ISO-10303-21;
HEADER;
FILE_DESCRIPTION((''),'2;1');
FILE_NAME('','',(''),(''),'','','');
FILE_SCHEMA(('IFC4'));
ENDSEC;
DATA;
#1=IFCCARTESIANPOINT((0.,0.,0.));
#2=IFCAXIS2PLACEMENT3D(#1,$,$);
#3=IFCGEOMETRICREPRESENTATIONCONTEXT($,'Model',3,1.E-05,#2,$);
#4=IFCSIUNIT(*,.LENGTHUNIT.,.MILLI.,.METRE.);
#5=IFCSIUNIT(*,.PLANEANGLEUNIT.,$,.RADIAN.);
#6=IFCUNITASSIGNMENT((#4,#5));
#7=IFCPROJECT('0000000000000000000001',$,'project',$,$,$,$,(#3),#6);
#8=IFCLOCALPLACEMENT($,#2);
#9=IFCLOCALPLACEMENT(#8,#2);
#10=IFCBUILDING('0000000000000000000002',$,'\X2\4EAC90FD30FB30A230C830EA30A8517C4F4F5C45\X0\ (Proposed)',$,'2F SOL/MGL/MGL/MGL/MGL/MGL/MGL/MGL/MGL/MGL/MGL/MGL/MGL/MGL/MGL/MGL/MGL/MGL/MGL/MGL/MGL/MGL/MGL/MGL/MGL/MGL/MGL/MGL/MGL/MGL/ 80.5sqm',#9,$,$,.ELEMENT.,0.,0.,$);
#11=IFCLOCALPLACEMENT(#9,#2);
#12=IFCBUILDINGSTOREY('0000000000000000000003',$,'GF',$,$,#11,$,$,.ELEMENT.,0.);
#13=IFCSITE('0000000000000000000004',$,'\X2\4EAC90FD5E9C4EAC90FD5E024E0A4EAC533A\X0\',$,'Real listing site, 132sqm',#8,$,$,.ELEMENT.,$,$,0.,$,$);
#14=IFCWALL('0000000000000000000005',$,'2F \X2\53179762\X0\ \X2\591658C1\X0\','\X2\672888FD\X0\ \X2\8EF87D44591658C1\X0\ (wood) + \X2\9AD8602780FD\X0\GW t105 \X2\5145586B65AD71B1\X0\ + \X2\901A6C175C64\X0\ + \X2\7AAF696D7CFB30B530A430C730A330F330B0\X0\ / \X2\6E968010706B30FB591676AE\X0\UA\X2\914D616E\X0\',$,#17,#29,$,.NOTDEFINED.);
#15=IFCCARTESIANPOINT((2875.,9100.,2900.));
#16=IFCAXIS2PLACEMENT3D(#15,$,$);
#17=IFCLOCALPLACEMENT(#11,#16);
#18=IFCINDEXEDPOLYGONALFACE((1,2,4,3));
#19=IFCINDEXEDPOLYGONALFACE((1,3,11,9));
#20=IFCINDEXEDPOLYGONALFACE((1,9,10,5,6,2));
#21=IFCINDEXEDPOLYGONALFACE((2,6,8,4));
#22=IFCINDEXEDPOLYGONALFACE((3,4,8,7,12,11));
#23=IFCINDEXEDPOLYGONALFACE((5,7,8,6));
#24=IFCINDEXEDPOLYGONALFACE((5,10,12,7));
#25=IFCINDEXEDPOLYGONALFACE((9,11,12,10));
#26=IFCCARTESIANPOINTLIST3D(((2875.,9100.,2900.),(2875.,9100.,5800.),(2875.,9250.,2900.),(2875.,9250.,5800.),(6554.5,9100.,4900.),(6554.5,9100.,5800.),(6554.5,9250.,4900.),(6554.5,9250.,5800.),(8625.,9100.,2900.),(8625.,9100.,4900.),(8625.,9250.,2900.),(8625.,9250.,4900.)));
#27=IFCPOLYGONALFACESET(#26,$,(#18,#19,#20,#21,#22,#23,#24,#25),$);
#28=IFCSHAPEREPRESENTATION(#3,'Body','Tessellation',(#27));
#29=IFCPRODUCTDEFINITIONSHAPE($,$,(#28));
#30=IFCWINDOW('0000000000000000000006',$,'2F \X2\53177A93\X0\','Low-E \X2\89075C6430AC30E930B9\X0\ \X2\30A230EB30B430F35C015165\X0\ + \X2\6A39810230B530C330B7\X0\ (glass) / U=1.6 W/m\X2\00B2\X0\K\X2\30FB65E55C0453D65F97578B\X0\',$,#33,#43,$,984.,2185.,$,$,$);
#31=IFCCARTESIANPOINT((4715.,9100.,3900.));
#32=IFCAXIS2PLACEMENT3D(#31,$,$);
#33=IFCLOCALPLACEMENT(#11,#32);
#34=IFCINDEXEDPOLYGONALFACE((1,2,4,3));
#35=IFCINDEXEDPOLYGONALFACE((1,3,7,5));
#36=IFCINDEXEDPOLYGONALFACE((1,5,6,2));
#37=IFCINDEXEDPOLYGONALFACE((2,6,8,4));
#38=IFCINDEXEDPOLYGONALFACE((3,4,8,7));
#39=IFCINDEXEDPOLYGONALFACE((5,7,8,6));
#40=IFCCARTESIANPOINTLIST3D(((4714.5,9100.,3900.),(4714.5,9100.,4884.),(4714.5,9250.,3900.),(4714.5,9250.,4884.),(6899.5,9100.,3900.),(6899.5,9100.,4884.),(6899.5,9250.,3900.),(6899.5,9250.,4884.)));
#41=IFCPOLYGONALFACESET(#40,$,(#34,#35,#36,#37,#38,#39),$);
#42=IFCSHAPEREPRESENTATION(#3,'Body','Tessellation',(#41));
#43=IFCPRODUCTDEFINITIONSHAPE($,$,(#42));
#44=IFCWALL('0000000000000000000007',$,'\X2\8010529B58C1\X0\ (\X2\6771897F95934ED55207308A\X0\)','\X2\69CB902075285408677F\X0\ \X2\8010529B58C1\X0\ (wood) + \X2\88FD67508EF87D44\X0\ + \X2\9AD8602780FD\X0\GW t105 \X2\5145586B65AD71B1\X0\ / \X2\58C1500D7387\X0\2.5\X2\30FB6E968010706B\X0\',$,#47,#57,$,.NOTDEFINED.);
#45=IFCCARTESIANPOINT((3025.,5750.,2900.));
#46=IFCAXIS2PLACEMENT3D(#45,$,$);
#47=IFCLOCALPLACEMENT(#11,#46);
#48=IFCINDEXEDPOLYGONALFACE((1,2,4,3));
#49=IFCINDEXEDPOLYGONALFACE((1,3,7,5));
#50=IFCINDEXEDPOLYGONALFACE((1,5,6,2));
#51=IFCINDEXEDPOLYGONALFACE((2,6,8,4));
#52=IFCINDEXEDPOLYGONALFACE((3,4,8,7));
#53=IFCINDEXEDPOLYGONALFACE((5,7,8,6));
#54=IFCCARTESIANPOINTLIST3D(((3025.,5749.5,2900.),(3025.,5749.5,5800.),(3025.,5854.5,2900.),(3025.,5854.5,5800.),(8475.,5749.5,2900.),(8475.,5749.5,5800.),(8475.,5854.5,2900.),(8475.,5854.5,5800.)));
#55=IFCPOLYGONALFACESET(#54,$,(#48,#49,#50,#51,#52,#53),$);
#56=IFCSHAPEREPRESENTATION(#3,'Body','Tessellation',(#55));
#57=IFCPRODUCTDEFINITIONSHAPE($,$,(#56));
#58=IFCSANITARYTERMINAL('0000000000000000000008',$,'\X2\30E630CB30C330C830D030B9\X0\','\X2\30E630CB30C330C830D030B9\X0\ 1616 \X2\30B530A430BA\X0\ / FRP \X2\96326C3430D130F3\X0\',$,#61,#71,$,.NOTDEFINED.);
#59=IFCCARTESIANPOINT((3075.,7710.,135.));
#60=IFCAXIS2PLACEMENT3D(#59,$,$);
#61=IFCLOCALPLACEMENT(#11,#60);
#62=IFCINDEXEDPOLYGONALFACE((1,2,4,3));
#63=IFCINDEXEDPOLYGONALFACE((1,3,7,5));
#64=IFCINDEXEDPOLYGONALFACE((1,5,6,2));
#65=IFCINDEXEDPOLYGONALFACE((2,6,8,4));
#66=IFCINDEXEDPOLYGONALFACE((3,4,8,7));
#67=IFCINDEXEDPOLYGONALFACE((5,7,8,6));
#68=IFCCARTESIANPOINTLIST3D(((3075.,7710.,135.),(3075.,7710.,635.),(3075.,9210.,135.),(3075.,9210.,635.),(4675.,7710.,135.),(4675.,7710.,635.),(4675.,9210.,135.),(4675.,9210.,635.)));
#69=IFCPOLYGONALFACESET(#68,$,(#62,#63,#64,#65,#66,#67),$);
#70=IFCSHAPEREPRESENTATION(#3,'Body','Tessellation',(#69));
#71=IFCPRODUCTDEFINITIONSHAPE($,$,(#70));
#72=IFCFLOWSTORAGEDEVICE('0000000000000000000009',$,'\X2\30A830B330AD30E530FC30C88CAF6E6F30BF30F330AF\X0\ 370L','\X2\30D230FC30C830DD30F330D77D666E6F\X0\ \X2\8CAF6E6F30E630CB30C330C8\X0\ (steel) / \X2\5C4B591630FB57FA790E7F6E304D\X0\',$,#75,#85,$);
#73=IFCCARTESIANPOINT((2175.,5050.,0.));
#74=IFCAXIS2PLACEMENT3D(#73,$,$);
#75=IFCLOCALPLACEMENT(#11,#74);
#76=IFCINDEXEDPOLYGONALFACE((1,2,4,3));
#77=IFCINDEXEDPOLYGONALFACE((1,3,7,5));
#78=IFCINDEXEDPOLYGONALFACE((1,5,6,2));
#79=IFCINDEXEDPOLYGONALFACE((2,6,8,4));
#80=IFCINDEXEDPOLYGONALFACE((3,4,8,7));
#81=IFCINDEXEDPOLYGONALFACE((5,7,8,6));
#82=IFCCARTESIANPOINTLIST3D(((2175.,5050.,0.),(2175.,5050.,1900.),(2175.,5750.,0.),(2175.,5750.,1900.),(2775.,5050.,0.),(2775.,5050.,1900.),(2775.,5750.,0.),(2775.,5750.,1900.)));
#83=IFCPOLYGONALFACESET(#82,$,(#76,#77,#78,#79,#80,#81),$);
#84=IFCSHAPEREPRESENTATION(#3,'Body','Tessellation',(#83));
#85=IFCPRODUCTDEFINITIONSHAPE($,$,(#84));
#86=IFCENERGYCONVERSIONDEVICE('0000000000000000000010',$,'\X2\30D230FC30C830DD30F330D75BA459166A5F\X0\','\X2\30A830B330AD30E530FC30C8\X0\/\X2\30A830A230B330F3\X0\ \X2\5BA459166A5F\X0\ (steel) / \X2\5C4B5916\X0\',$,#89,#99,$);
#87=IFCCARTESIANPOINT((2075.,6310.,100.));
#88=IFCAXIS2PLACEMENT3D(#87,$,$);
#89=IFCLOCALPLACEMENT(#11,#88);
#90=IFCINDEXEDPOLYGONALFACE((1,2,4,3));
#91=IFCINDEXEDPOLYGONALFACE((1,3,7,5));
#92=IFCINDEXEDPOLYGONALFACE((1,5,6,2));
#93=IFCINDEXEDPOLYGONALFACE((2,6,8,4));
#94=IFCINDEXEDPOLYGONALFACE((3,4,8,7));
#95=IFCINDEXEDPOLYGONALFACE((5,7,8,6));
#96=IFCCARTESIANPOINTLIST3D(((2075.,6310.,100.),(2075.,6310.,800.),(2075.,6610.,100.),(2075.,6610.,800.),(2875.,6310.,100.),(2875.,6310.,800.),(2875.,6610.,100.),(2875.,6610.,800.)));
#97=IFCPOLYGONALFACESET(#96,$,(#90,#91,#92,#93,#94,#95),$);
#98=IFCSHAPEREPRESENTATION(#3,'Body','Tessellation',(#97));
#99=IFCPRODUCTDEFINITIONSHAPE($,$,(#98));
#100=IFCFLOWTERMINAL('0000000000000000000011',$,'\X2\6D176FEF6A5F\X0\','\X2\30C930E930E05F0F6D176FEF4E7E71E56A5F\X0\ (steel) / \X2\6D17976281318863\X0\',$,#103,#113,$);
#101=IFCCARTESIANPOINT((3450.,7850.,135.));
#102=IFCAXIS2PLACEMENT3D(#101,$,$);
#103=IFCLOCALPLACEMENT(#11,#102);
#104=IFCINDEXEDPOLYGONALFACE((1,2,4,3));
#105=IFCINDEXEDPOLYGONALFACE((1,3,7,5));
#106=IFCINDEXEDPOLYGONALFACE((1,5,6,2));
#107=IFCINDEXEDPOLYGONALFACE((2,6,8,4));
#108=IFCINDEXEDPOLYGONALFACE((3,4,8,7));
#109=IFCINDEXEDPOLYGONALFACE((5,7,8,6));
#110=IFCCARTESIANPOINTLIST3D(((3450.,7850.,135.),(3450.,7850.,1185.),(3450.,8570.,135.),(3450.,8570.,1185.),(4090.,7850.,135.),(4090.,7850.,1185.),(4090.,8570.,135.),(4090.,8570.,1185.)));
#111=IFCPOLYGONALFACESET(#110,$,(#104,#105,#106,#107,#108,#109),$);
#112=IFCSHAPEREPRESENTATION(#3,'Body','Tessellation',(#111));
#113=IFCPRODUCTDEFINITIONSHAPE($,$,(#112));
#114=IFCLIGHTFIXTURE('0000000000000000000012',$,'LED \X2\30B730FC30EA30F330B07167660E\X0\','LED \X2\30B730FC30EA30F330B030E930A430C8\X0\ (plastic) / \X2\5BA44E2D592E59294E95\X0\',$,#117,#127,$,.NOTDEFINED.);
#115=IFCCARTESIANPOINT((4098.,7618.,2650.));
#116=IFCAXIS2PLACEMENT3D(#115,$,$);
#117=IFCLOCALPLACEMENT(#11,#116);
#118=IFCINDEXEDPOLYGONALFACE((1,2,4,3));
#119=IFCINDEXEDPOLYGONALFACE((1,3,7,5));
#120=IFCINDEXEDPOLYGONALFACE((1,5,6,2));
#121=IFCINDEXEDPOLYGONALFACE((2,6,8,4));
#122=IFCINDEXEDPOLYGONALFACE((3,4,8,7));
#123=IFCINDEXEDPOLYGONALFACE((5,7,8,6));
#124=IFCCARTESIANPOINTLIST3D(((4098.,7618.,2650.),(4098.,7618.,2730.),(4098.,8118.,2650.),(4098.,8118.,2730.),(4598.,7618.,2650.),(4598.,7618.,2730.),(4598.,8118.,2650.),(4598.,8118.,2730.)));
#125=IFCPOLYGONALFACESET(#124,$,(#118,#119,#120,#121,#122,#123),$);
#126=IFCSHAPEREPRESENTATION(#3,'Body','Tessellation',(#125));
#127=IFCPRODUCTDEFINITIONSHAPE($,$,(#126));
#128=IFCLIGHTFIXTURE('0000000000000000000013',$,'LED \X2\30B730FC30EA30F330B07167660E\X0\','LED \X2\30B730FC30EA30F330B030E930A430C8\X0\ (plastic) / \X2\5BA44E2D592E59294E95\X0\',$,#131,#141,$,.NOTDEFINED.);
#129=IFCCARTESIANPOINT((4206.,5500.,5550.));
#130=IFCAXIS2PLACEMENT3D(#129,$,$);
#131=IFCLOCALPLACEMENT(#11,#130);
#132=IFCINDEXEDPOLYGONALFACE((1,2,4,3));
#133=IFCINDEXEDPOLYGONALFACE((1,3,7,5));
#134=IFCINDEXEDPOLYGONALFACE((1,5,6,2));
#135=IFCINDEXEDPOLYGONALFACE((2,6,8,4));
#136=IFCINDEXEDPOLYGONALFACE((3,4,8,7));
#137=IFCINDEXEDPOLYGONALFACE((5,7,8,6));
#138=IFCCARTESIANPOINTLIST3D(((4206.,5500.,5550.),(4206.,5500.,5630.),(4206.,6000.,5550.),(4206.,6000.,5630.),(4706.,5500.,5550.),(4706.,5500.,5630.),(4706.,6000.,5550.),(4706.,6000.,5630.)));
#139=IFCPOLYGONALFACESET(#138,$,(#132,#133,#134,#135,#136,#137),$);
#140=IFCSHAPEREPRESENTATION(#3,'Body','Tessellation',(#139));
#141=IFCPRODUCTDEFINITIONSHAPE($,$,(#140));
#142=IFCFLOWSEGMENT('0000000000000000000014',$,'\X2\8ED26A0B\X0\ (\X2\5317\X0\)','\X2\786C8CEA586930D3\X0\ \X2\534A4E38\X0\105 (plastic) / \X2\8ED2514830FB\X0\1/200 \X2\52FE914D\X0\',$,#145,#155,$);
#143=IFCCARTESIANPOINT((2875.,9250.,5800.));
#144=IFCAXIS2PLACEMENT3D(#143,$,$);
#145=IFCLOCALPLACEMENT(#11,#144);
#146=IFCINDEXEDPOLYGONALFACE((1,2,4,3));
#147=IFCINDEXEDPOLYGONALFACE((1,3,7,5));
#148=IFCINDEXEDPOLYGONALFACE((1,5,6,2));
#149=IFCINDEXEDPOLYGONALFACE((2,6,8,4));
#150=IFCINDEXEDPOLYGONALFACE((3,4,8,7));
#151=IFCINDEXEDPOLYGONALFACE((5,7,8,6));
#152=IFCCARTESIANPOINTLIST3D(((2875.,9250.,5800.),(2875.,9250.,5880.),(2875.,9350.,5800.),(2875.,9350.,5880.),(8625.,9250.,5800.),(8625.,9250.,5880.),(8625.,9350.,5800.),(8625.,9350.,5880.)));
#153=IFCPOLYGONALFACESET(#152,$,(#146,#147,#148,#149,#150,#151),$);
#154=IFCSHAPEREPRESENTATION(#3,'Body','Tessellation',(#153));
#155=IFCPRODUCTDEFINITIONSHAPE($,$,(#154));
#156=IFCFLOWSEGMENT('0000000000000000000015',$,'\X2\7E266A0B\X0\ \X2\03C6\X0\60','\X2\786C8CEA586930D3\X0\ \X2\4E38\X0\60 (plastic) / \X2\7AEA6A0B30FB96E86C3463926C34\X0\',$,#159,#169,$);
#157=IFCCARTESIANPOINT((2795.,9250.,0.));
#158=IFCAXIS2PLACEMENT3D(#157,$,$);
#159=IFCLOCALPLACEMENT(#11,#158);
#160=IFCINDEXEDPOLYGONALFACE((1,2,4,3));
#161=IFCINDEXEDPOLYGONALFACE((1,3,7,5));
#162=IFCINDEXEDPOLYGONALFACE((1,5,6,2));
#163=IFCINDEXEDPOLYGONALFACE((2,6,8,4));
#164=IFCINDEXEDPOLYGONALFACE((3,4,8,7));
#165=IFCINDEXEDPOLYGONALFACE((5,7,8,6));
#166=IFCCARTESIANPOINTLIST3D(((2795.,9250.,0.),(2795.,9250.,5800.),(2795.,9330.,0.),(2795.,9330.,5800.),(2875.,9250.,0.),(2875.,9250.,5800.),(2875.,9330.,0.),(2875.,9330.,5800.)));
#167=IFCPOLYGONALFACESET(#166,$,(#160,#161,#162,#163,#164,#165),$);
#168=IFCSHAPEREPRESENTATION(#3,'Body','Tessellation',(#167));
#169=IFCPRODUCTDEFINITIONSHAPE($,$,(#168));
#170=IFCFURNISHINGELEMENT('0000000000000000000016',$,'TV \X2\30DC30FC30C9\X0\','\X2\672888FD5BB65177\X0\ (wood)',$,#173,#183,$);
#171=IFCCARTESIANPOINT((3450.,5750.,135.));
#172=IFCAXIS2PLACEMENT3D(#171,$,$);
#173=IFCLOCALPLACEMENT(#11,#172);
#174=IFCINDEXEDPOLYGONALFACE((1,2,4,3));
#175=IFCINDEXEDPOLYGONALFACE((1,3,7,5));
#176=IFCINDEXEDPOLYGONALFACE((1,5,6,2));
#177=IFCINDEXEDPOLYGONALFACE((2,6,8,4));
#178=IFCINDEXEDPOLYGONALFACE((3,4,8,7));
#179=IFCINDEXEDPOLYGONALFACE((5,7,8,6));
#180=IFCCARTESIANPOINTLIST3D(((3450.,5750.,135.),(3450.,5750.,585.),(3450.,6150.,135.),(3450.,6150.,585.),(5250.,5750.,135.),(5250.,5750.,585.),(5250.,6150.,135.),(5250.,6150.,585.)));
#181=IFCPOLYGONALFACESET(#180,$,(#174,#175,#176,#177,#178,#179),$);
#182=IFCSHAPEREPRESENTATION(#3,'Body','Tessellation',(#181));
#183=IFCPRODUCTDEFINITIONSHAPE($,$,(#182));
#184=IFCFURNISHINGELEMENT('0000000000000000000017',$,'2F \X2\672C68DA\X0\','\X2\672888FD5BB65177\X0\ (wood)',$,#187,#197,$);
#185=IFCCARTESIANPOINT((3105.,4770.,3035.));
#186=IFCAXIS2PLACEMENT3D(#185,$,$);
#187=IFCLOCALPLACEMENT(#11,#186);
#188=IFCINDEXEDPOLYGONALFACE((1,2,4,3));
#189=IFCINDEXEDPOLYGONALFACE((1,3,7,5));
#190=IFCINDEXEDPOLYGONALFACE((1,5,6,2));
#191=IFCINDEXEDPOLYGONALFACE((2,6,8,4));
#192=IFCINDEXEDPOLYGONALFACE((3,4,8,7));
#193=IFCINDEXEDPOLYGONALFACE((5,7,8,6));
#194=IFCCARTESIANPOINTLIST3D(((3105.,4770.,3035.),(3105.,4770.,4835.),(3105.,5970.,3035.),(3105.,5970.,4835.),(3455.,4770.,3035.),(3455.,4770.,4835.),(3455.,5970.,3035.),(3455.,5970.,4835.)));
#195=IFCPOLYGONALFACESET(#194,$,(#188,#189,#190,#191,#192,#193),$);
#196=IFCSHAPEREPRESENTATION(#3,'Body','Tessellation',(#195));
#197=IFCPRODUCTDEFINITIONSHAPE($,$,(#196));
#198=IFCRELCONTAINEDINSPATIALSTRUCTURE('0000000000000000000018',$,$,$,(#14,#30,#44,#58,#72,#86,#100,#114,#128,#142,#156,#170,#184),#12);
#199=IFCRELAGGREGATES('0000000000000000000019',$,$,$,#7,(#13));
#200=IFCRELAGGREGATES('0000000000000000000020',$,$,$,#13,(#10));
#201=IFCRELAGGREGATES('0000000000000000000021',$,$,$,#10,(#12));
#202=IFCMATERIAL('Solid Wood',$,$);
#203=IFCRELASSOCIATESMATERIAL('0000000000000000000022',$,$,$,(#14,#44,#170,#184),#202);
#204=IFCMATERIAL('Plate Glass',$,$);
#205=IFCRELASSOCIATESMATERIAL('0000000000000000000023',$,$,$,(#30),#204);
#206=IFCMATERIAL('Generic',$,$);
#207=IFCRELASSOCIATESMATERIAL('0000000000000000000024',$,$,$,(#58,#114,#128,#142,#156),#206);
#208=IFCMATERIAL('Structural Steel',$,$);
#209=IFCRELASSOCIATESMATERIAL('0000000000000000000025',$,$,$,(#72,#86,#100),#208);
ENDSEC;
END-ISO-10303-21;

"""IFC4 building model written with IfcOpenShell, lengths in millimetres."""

from ifc_helpers import new_model, si_unit, frame, frame_2d, origin, place, context, project, spatial, rectangle, extrude, material, element, fill, save


model = new_model("IFC4")

# Units and contexts
model_context = context("Model", 3, precision=1e-05, world=origin())
ifc_project = project(units=[si_unit("LENGTHUNIT", "METRE", prefix="MILLI"), si_unit("PLANEANGLEUNIT", "RADIAN")], contexts=[model_context])

# Site, building, storey
site_placement = place(None, origin())
site = spatial("IfcSite", under=ifc_project, at=site_placement, Name="京都府京都市上京区", ObjectType="Real listing site, 132sqm", CompositionType="ELEMENT", RefElevation=0.0)
building_placement = place(site_placement, origin())
building = spatial("IfcBuilding", under=site, at=building_placement, Name="京都・アトリエ兼住居 (Proposed)", ObjectType="2F SOL/MGL/MGL/MGL/MGL/MGL/MGL/MGL/MGL/MGL/MGL/MGL/MGL/MGL/MGL/MGL/MGL/MGL/MGL/MGL/MGL/MGL/MGL/MGL/MGL/MGL/MGL/MGL/MGL/MGL/ 80.5sqm", CompositionType="ELEMENT", ElevationOfRefHeight=0.0, ElevationOfTerrain=0.0)
storey_placement = place(building_placement, origin())
storey = spatial("IfcBuildingStorey", under=building, at=storey_placement, Name="GF", CompositionType="ELEMENT", Elevation=0.0)

# Shared definitions
ifc_material_1 = material(Name="Solid Wood")

# Shared definitions
ifc_material_2 = material(Name="Plate Glass")

# Wall, opening, window
wall_1_placement = place(storey_placement, frame((2875.0, 9100.0, 2900.0)))
wall_1 = element("IfcWall", 1, at=wall_1_placement, inside=storey, material=ifc_material_1, Name="2F 北面 外壁", Description="木製 軸組外壁 (wood) + 高性能GW t105 充填断熱 + 通気層 + 窯業系サイディング / 準耐火・外皮UA配慮", PredefinedType="NOTDEFINED", context=model_context, shape_type="SweptSolid", body=[
    extrude(rectangle(XDim=5750.0, YDim=150.0, at=frame_2d((2875.0, 75.0))), frame((2875.0, 9100.0, 2900.0)), (0.0, 0.0, 1.0), 2900.0),
])
opening_1_placement = place(storey_placement, frame((4715.0, 9100.0, 3900.0)))
opening_1 = element("IfcOpeningElement", 2, at=opening_1_placement, cuts=wall_1, PredefinedType="NOTDEFINED", context=model_context, shape_type="SweptSolid", body=[
    extrude(rectangle(XDim=2185.0, YDim=150.0, at=frame_2d((1092.0, 75.0))), frame((4715.0, 9100.0, 3900.0)), (0.0, 0.0, 1.0), 984.0),
])
window_1_placement = place(storey_placement, frame((4715.0, 9100.0, 3900.0)))
window_1 = element("IfcWindow", 3, at=window_1_placement, inside=storey, material=ifc_material_2, Name="2F 北窓", Description="Low-E 複層ガラス アルゴン封入 + 樹脂サッシ (glass) / U=1.6 W/m²K・日射取得型", OverallHeight=984.0, OverallWidth=2185.0, context=model_context, shape_type="SweptSolid", body=[
    extrude(rectangle(XDim=2185.0, YDim=150.0, at=frame_2d((1092.0, 75.0))), frame((4715.0, 9100.0, 3900.0)), (0.0, 0.0, 1.0), 984.0),
])
fill(opening_1, window_1)

# Wall
wall_2_placement = place(storey_placement, frame((3025.0, 5750.0, 2900.0)))
element("IfcWall", 4, at=wall_2_placement, inside=storey, material=ifc_material_1, Name="耐力壁 (東西間仕切り)", Description="構造用合板 耐力壁 (wood) + 製材軸組 + 高性能GW t105 充填断熱 / 壁倍率2.5・準耐火", PredefinedType="NOTDEFINED", context=model_context, shape_type="SweptSolid", body=[
    extrude(rectangle(XDim=5450.0, YDim=105.0, at=frame_2d((2725.0, 52.0))), frame((3025.0, 5750.0, 2900.0)), (0.0, 0.0, 1.0), 2900.0),
])

# Sanitary terminal
ifc_material_3 = material(Name="Generic")
sanitary_terminal_placement = place(storey_placement, frame((3075.0, 7710.0, 135.0)))
element("IfcSanitaryTerminal", 5, at=sanitary_terminal_placement, inside=storey, material=ifc_material_3, Name="ユニットバス", Description="ユニットバス 1616 サイズ / FRP 防水パン", PredefinedType="NOTDEFINED", context=model_context, shape_type="SweptSolid", body=[
    extrude(rectangle(XDim=1600.0, YDim=1500.0, at=frame_2d((800.0, 750.0))), frame((3075.0, 7710.0, 135.0)), (0.0, 0.0, 1.0), 500.0),
])

# Flow storage device
ifc_material_4 = material(Name="Structural Steel")
flow_storage_device_placement = place(storey_placement, frame((2175.0, 5050.0, 0.0)))
element("IfcFlowStorageDevice", 6, at=flow_storage_device_placement, inside=storey, material=ifc_material_4, Name="エコキュート貯湯タンク 370L", Description="ヒートポンプ給湯 貯湯ユニット (steel) / 屋外・基礎置き", context=model_context, shape_type="SweptSolid", body=[
    extrude(rectangle(XDim=600.0, YDim=700.0, at=frame_2d((300.0, 350.0))), frame((2175.0, 5050.0, 0.0)), (0.0, 0.0, 1.0), 1900.0),
])

# Energy conversion device
energy_conversion_device_placement = place(storey_placement, frame((2075.0, 6310.0, 100.0)))
element("IfcEnergyConversionDevice", 7, at=energy_conversion_device_placement, inside=storey, material=ifc_material_4, Name="ヒートポンプ室外機", Description="エコキュート/エアコン 室外機 (steel) / 屋外", context=model_context, shape_type="SweptSolid", body=[
    extrude(rectangle(XDim=800.0, YDim=300.0, at=frame_2d((400.0, 150.0))), frame((2075.0, 6310.0, 100.0)), (0.0, 0.0, 1.0), 700.0),
])

# Flow terminal
flow_terminal_placement = place(storey_placement, frame((3450.0, 7850.0, 135.0)))
element("IfcFlowTerminal", 8, at=flow_terminal_placement, inside=storey, material=ifc_material_4, Name="洗濯機", Description="ドラム式洗濯乾燥機 (steel) / 洗面脱衣", context=model_context, shape_type="SweptSolid", body=[
    extrude(rectangle(XDim=640.0, YDim=720.0, at=frame_2d((320.0, 360.0))), frame((3450.0, 7850.0, 135.0)), (0.0, 0.0, 1.0), 1050.0),
])

# Light fixtures
light_fixture_1_placement = place(storey_placement, frame((4098.0, 7618.0, 2650.0)))
element("IfcLightFixture", 9, at=light_fixture_1_placement, inside=storey, material=ifc_material_3, Name="LED シーリング照明", Description="LED シーリングライト (plastic) / 室中央天井", PredefinedType="NOTDEFINED", context=model_context, shape_type="SweptSolid", body=[
    extrude(rectangle(XDim=500.0, YDim=500.0, at=frame_2d((250.0, 250.0))), frame((4098.0, 7618.0, 2650.0)), (0.0, 0.0, 1.0), 80.0),
])
light_fixture_2_placement = place(storey_placement, frame((4206.0, 5500.0, 5550.0)))
element("IfcLightFixture", 10, at=light_fixture_2_placement, inside=storey, material=ifc_material_3, Name="LED シーリング照明", Description="LED シーリングライト (plastic) / 室中央天井", PredefinedType="NOTDEFINED", context=model_context, shape_type="SweptSolid", body=[
    extrude(rectangle(XDim=500.0, YDim=500.0, at=frame_2d((250.0, 250.0))), frame((4206.0, 5500.0, 5550.0)), (0.0, 0.0, 1.0), 80.0),
])

# Flow segments
flow_segment_1_placement = place(storey_placement, frame((2875.0, 9250.0, 5800.0)))
element("IfcFlowSegment", 11, at=flow_segment_1_placement, inside=storey, material=ifc_material_3, Name="軒樋 (北)", Description="硬質塩ビ 半丸105 (plastic) / 軒先・1/200 勾配", context=model_context, shape_type="SweptSolid", body=[
    extrude(rectangle(XDim=5750.0, YDim=100.0, at=frame_2d((2875.0, 50.0))), frame((2875.0, 9250.0, 5800.0)), (0.0, 0.0, 1.0), 80.0),
])
flow_segment_2_placement = place(storey_placement, frame((2795.0, 9250.0, 0.0)))
element("IfcFlowSegment", 12, at=flow_segment_2_placement, inside=storey, material=ifc_material_3, Name="縦樋 φ60", Description="硬質塩ビ 丸60 (plastic) / 竪樋・雨水排水", context=model_context, shape_type="SweptSolid", body=[
    extrude(rectangle(XDim=80.0, YDim=80.0, at=frame_2d((40.0, 40.0))), frame((2795.0, 9250.0, 0.0)), (0.0, 0.0, 1.0), 5800.0),
])

# Furnishing elements
furnishing_1_placement = place(storey_placement, frame((3450.0, 5750.0, 135.0)))
element("IfcFurnishingElement", 13, at=furnishing_1_placement, inside=storey, material=ifc_material_1, Name="TV ボード", Description="木製家具 (wood)", context=model_context, shape_type="SweptSolid", body=[
    extrude(rectangle(XDim=1800.0, YDim=400.0, at=frame_2d((900.0, 200.0))), frame((3450.0, 5750.0, 135.0)), (0.0, 0.0, 1.0), 450.0),
])
furnishing_2_placement = place(storey_placement, frame((3105.0, 4770.0, 3035.0)))
element("IfcFurnishingElement", 14, at=furnishing_2_placement, inside=storey, material=ifc_material_1, Name="2F 本棚", Description="木製家具 (wood)", context=model_context, shape_type="SweptSolid", body=[
    extrude(rectangle(XDim=350.0, YDim=1200.0, at=frame_2d((175.0, 600.0))), frame((3105.0, 4770.0, 3035.0)), (0.0, 0.0, 1.0), 1800.0),
])

save(model, "model.ifc")
